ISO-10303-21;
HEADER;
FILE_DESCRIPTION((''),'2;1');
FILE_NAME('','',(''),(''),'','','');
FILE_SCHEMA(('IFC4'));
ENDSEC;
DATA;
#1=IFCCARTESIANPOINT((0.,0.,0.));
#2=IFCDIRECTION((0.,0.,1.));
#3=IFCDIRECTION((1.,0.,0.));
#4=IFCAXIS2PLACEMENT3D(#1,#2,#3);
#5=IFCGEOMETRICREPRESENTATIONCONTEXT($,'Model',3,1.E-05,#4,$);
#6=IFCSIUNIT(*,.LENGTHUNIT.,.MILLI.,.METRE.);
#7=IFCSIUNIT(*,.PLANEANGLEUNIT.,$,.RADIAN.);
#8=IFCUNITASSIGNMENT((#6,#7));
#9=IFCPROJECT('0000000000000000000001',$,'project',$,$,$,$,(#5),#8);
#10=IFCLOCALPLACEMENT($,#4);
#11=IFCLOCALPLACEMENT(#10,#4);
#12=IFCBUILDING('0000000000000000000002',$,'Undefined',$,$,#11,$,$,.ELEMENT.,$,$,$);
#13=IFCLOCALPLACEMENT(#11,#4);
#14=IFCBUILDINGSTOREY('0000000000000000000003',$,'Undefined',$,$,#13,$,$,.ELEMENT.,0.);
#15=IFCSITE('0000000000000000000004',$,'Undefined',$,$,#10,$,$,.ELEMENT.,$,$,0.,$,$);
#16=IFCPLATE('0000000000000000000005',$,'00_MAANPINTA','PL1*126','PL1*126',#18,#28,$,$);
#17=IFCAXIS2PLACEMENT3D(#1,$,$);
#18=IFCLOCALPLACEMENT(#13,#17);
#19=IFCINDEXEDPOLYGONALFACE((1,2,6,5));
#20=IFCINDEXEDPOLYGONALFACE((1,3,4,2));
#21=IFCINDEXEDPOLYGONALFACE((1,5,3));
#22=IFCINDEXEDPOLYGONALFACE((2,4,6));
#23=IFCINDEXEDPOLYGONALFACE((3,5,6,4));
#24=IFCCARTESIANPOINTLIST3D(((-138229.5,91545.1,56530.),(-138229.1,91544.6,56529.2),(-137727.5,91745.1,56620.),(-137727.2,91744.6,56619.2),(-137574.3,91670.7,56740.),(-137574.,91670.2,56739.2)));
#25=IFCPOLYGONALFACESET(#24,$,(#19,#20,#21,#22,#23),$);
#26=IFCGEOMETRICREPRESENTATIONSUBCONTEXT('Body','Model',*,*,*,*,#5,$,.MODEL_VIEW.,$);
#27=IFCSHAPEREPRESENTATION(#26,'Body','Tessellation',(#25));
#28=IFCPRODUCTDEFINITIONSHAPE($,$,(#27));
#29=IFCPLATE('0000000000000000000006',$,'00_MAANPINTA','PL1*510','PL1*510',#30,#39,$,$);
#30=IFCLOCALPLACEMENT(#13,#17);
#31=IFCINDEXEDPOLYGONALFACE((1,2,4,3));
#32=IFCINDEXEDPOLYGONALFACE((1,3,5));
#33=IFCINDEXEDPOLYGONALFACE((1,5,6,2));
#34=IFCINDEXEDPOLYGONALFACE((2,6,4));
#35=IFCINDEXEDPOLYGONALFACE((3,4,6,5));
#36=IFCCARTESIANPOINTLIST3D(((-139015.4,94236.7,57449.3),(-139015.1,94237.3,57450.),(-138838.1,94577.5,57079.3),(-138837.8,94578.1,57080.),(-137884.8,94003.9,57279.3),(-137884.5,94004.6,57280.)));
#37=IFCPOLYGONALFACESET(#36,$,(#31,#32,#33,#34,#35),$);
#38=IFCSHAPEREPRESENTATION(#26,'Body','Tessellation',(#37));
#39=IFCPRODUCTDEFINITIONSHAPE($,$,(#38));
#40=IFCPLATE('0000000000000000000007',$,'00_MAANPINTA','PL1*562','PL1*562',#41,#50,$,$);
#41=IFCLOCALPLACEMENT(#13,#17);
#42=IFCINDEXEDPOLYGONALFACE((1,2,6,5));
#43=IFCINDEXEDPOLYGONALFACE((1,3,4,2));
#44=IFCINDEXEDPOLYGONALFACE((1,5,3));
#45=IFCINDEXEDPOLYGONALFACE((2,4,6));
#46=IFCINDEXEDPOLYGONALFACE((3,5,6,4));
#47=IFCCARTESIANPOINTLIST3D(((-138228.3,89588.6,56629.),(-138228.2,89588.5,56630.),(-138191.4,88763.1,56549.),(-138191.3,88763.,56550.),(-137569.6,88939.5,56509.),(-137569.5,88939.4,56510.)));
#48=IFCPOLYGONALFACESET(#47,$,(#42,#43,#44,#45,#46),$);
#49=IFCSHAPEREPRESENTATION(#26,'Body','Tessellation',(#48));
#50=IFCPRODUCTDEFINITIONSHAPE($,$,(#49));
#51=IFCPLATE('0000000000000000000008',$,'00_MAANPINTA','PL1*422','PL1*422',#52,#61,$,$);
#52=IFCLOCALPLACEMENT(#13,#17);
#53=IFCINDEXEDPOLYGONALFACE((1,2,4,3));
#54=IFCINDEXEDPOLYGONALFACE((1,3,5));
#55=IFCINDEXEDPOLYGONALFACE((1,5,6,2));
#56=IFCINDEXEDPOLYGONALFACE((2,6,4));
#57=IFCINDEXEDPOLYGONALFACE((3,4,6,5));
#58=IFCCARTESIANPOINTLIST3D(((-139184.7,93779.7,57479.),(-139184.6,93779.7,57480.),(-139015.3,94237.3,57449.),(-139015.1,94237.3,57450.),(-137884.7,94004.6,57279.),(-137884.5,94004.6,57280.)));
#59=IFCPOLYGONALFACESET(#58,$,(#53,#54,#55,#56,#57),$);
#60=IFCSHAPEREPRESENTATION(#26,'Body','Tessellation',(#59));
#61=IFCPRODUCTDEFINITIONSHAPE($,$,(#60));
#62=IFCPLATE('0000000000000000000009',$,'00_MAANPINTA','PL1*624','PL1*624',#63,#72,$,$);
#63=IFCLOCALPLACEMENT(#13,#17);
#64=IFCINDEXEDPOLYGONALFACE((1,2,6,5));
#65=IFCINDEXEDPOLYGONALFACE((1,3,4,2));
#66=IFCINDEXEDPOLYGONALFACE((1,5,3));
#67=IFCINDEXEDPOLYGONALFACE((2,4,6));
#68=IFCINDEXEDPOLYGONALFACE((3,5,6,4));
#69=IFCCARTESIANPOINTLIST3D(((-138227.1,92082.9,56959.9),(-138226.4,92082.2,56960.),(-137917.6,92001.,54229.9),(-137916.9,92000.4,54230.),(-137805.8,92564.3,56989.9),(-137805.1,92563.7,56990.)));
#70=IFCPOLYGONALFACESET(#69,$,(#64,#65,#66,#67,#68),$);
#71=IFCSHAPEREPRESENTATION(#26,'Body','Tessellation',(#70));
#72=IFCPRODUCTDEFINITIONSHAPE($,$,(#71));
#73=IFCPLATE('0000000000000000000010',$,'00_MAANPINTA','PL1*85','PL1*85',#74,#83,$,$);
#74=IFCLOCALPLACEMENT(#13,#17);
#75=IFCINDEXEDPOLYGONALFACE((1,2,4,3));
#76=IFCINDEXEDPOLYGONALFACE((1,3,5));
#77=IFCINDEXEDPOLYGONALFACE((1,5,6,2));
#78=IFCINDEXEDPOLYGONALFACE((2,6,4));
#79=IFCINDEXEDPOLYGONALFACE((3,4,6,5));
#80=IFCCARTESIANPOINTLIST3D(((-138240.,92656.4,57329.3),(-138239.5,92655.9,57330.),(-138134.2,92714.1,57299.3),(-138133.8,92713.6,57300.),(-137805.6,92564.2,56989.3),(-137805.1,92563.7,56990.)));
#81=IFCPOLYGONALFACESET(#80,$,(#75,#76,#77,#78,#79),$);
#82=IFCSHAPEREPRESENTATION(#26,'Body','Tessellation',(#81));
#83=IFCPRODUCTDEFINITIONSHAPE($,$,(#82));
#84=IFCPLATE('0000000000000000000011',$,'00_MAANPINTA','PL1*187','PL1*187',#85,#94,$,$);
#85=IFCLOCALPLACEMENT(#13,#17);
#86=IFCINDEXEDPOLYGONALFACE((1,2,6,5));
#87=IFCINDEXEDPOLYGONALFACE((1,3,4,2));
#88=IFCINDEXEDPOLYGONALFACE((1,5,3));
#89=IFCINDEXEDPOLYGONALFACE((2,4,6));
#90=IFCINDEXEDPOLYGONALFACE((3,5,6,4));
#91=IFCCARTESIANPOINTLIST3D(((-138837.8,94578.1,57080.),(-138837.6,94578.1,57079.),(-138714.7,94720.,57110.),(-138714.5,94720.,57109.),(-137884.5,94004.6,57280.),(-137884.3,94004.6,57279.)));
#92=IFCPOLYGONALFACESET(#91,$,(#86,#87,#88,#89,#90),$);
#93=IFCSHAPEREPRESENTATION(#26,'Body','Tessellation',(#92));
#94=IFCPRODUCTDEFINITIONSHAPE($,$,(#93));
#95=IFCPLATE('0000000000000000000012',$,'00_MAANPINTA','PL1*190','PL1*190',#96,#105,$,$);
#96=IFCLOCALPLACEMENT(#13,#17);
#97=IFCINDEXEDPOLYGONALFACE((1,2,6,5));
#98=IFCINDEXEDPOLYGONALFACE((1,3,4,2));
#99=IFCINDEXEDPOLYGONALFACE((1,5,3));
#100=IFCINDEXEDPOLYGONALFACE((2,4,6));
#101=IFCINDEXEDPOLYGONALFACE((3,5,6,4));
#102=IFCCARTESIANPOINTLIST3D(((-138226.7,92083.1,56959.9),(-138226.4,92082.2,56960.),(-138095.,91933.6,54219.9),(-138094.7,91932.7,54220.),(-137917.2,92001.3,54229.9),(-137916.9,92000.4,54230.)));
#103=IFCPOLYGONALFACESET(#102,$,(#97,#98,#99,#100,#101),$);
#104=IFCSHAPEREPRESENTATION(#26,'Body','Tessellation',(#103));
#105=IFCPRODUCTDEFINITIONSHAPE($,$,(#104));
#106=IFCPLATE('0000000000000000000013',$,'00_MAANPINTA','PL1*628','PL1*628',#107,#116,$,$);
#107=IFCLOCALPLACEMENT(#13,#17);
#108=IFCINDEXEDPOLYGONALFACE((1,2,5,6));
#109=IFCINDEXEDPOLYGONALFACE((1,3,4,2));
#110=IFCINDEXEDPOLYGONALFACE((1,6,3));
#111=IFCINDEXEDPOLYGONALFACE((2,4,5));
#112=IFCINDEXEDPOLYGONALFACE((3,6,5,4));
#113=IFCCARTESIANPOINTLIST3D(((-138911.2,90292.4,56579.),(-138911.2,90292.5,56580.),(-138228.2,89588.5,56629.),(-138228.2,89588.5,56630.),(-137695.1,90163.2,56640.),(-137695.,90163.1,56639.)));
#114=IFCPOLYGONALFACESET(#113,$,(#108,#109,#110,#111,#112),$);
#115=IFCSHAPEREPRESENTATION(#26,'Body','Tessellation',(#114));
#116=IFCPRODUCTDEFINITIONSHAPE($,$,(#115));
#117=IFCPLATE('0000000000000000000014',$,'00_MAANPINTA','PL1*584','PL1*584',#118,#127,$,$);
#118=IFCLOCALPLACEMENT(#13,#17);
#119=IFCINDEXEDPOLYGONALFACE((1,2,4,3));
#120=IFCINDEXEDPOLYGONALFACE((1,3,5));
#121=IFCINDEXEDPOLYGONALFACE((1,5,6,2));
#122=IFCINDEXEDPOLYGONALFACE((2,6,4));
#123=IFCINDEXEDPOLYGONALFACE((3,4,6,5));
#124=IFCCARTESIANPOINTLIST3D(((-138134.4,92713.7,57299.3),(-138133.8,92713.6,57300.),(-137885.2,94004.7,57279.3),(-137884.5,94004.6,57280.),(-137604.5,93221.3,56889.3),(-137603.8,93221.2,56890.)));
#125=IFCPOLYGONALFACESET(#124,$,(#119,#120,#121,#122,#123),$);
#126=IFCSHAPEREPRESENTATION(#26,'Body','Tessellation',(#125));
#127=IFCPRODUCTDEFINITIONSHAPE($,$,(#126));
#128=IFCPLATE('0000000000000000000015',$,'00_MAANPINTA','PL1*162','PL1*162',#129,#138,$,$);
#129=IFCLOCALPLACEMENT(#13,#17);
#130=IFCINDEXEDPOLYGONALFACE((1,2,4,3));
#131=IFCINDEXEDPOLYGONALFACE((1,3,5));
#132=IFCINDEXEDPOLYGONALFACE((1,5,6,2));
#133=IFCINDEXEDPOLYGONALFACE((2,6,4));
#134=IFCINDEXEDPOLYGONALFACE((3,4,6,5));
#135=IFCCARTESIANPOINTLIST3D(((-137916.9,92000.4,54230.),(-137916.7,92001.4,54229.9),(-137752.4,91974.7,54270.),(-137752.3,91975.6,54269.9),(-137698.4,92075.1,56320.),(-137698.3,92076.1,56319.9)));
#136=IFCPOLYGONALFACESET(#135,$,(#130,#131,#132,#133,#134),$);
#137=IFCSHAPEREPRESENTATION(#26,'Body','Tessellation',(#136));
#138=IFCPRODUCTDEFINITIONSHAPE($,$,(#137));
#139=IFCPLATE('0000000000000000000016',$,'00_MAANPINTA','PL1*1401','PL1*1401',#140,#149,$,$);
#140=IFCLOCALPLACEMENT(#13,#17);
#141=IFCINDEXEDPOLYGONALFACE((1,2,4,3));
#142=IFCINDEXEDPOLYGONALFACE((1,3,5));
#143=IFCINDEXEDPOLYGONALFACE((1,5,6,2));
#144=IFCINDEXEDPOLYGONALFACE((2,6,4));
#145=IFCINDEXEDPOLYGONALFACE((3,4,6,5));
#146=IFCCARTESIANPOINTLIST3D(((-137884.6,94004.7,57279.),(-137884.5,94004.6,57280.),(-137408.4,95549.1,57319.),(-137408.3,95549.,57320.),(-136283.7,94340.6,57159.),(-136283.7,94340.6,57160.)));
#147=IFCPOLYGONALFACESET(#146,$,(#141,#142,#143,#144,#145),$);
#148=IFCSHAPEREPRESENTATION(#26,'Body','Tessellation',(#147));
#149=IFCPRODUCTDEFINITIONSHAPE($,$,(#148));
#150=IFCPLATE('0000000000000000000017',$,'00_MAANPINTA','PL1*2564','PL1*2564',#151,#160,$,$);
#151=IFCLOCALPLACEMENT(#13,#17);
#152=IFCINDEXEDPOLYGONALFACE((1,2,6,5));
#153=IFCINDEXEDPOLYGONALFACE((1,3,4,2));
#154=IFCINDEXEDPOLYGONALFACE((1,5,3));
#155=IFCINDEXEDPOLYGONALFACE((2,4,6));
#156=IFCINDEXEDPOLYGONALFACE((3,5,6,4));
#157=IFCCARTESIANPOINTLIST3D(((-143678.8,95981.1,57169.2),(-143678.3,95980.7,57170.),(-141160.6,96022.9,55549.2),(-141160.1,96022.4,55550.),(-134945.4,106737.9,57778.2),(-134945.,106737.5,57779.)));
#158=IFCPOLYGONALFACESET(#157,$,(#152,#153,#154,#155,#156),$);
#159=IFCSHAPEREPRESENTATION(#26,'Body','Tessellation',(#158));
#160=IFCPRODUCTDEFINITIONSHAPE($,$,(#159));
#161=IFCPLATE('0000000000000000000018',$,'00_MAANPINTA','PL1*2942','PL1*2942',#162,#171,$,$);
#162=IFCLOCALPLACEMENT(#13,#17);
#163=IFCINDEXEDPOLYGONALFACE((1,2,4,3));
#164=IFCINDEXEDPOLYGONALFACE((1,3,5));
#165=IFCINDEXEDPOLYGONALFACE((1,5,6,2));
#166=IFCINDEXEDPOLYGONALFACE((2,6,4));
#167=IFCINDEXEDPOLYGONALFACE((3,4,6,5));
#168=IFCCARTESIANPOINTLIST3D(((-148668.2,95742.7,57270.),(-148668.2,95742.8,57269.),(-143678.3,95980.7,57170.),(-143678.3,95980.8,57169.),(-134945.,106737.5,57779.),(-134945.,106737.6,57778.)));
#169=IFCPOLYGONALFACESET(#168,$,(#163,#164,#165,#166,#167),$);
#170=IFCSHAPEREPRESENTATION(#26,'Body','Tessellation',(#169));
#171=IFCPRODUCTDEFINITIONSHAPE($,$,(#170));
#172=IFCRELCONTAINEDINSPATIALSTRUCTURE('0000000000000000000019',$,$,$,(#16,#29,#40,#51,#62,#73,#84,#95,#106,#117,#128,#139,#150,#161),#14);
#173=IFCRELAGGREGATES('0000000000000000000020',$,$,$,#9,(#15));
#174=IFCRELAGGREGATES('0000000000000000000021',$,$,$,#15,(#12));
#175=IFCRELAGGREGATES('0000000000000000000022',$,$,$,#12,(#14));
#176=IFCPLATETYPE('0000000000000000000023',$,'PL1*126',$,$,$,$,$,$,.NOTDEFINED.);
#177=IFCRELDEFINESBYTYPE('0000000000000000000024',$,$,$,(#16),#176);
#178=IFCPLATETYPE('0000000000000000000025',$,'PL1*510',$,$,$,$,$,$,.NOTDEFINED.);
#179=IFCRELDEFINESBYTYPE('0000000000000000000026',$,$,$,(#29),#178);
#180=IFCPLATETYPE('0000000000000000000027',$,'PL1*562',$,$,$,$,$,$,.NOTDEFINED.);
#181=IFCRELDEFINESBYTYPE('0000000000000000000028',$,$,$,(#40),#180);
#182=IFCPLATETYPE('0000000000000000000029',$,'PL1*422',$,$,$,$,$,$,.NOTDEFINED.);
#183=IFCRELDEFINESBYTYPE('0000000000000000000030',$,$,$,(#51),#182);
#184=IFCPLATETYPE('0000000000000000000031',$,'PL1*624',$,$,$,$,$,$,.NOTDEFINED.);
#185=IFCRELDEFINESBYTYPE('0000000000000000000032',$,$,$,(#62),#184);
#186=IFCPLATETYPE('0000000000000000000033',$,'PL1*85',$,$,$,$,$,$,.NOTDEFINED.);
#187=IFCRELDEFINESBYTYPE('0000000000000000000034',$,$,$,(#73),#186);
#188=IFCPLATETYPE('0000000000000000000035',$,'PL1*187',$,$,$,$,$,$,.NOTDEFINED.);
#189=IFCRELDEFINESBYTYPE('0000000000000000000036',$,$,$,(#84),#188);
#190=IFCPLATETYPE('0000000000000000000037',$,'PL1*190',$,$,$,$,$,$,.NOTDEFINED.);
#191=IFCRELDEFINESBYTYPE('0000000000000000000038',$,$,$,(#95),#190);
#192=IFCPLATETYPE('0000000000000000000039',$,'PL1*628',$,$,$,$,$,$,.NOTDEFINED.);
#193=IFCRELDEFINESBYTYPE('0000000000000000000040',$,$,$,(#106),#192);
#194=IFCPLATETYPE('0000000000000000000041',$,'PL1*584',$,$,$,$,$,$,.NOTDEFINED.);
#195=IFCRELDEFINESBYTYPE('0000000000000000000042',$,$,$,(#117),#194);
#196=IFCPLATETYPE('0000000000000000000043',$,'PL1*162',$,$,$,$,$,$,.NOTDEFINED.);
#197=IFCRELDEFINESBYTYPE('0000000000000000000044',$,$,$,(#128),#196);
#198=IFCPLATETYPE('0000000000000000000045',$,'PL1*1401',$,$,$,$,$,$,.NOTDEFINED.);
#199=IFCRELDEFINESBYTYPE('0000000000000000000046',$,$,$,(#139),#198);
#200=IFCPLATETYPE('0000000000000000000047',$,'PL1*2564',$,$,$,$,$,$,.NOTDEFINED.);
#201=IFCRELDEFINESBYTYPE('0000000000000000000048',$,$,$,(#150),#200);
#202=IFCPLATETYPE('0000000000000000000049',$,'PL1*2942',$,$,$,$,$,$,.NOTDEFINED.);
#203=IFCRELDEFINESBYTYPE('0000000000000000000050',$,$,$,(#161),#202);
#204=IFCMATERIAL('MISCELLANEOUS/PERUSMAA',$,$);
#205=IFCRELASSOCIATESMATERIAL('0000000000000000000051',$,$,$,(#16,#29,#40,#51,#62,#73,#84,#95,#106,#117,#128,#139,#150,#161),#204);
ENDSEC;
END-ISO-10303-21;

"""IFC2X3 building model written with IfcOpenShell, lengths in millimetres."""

from ifc_helpers import new_model, si_unit, frame, origin_with_axes, place, context, subcontext, project, spatial, polyline, outline, extrude, material, type_object, element, save


model = new_model("IFC2X3")

# Units and contexts
model_context = context("Model", 3, precision=1e-05, world=origin_with_axes())
body_context = subcontext(model_context, "Body", "Model", "MODEL_VIEW")
ifc_project = project(units=[si_unit("LENGTHUNIT", "METRE", prefix="MILLI"), si_unit("PLANEANGLEUNIT", "RADIAN")], contexts=[model_context])

# Site, building, storey
site_placement = place(None, origin_with_axes())
site = spatial("IfcSite", under=ifc_project, at=site_placement, Name="Undefined", CompositionType="ELEMENT", RefElevation=0.0)
building_placement = place(site_placement, origin_with_axes())
building = spatial("IfcBuilding", under=site, at=building_placement, Name="Undefined", CompositionType="ELEMENT")
storey_placement = place(building_placement, origin_with_axes())
storey = spatial("IfcBuildingStorey", under=building, at=storey_placement, Name="Undefined", CompositionType="ELEMENT", Elevation=0.0)

# Plates
ifc_material = material(Name="MISCELLANEOUS/PERUSMAA")
plate_type_1 = type_object("IfcPlateType", Name="PL1*126", PredefinedType="NOTDEFINED")
plate_1_placement = place(storey_placement, frame((-138229.3, 91544.8, 56529.6), z_axis=(0.349353, -0.528524, -0.773702), x_axis=(0.916324, 0.365185, 0.164289)))
element("IfcPlate", 1, at=plate_1_placement, inside=storey, type_object=plate_type_1, material=ifc_material, Name="00_MAANPINTA", Description="PL1*126", ObjectType="PL1*126", context=body_context, shape_type="SweptSolid", body=[
    extrude(outline(polyline([(0.0, 0.0), (547.8, 0.0), (680.7, 160.4), (0.0, 0.0)])), frame((0.0, 0.0, -0.5), z_axis=(0.0, 0.0, 1.0), x_axis=(1.0, 0.0, 0.0)), (0.0, 0.0, 1.0), 1.0),
])
plate_type_2 = type_object("IfcPlateType", Name="PL1*510", PredefinedType="NOTDEFINED")
plate_2_placement = place(storey_placement, frame((-139015.3, 94237.0, 57449.6), z_axis=(-0.242286, -0.652972, -0.717583), x_axis=(0.332479, 0.638954, -0.693682)))
element("IfcPlate", 2, at=plate_2_placement, inside=storey, type_object=plate_type_2, material=ifc_material, Name="00_MAANPINTA", Description="PL1*510", ObjectType="PL1*510", context=body_context, shape_type="SweptSolid", body=[
    extrude(outline(polyline([(0.0, 0.0), (533.4, 0.0), (345.2, 1114.6), (0.0, 0.0)])), frame((0.0, 0.0, -0.5), z_axis=(0.0, 0.0, 1.0), x_axis=(1.0, 0.0, 0.0)), (0.0, 0.0, 1.0), 1.0),
])
plate_type_3 = type_object("IfcPlateType", Name="PL1*562", PredefinedType="NOTDEFINED")
plate_3_placement = place(storey_placement, frame((-138228.3, 89588.6, 56629.5), z_axis=(-0.089933, 0.092072, -0.991683), x_axis=(0.706365, -0.696053, -0.128683)))
element("IfcPlate", 3, at=plate_3_placement, inside=storey, type_object=plate_type_3, material=ifc_material, Name="00_MAANPINTA", Description="PL1*562", ObjectType="PL1*562", context=body_context, shape_type="SweptSolid", body=[
    extrude(outline(polyline([(0.0, 0.0), (932.5, 0.0), (611.0, 562.1), (0.0, 0.0)])), frame((0.0, 0.0, -0.5), z_axis=(0.0, 0.0, 1.0), x_axis=(1.0, 0.0, 0.0)), (0.0, 0.0, 1.0), 1.0),
])
plate_type_4 = type_object("IfcPlateType", Name="PL1*422", PredefinedType="NOTDEFINED")
plate_4_placement = place(storey_placement, frame((-139184.7, 93779.7, 57479.5), z_axis=(-0.150507, -0.009079, -0.988567), x_axis=(0.346603, 0.936002, -0.061365)))
element("IfcPlate", 4, at=plate_4_placement, inside=storey, type_object=plate_type_4, material=ifc_material, Name="00_MAANPINTA", Description="PL1*422", ObjectType="PL1*422", context=body_context, shape_type="SweptSolid", body=[
    extrude(outline(polyline([(0.0, 0.0), (488.9, 0.0), (673.4, 1152.1), (0.0, 0.0)])), frame((0.0, 0.0, -0.5), z_axis=(0.0, 0.0, 1.0), x_axis=(1.0, 0.0, 0.0)), (0.0, 0.0, 1.0), 1.0),
])
plate_type_5 = type_object("IfcPlateType", Name="PL1*624", PredefinedType="NOTDEFINED")
plate_5_placement = place(storey_placement, frame((-137917.2, 92000.7, 54229.9), z_axis=(-0.745235, 0.658605, -0.104235), x_axis=(-0.112606, 0.029772, 0.993194)))
element("IfcPlate", 5, at=plate_5_placement, inside=storey, type_object=plate_type_5, material=ifc_material, Name="00_MAANPINTA", Description="PL1*624", ObjectType="PL1*624", context=body_context, shape_type="SweptSolid", body=[
    extrude(outline(polyline([(0.0, 0.0), (2748.7, 0.0), (2745.4, 640.5), (0.0, 0.0)])), frame((0.0, 0.0, -0.5), z_axis=(0.0, 0.0, 1.0), x_axis=(1.0, 0.0, 0.0)), (0.0, 0.0, 1.0), 1.0),
])
plate_type_6 = type_object("IfcPlateType", Name="PL1*85", PredefinedType="NOTDEFINED")
plate_6_placement = place(storey_placement, frame((-137805.3, 92563.9, 56989.6), z_axis=(-0.473107, 0.484434, -0.735863), x_axis=(-0.776684, 0.164914, 0.607919)))
element("IfcPlate", 6, at=plate_6_placement, inside=storey, type_object=plate_type_6, material=ifc_material, Name="00_MAANPINTA", Description="PL1*85", ObjectType="PL1*85", context=body_context, shape_type="SweptSolid", body=[
    extrude(outline(polyline([(0.0, 0.0), (559.3, 0.0), (468.5, 84.6), (0.0, 0.0)])), frame((0.0, 0.0, -0.5), z_axis=(0.0, 0.0, 1.0), x_axis=(1.0, 0.0, 0.0)), (0.0, 0.0, 1.0), 1.0),
])
plate_type_7 = type_object("IfcPlateType", Name="PL1*187", PredefinedType="NOTDEFINED")
plate_7_placement = place(storey_placement, frame((-138837.7, 94578.1, 57079.5), z_axis=(0.216129, 0.018831, -0.976183), x_axis=(0.647187, 0.745847, 0.157676)))
element("IfcPlate", 7, at=plate_7_placement, inside=storey, type_object=plate_type_7, material=ifc_material, Name="00_MAANPINTA", Description="PL1*187", ObjectType="PL1*187", context=body_context, shape_type="SweptSolid", body=[
    extrude(outline(polyline([(0.0, 0.0), (190.3, 0.0), (220.7, 1108.6), (0.0, 0.0)])), frame((0.0, 0.0, -0.5), z_axis=(0.0, 0.0, 1.0), x_axis=(1.0, 0.0, 0.0)), (0.0, 0.0, 1.0), 1.0),
])
plate_type_8 = type_object("IfcPlateType", Name="PL1*190", PredefinedType="NOTDEFINED")
plate_8_placement = place(storey_placement, frame((-138226.6, 92082.7, 56960.0), z_axis=(-0.351559, 0.933704, -0.067848), x_axis=(0.112606, -0.029772, -0.993194)))
element("IfcPlate", 8, at=plate_8_placement, inside=storey, type_object=plate_type_8, material=ifc_material, Name="00_MAANPINTA", Description="PL1*190", ObjectType="PL1*190", context=body_context, shape_type="SweptSolid", body=[
    extrude(outline(polyline([(0.0, 0.0), (2748.7, 0.0), (2740.6, 190.4), (0.0, 0.0)])), frame((0.0, 0.0, -0.5), z_axis=(0.0, 0.0, 1.0), x_axis=(1.0, 0.0, 0.0)), (0.0, 0.0, 1.0), 1.0),
])
plate_type_9 = type_object("IfcPlateType", Name="PL1*628", PredefinedType="NOTDEFINED")
plate_9_placement = place(storey_placement, frame((-138228.2, 89588.5, 56629.5), z_axis=(0.046525, -0.025789, -0.998584), x_axis=(-0.695418, 0.7168, -0.050912)))
element("IfcPlate", 9, at=plate_9_placement, inside=storey, type_object=plate_type_9, material=ifc_material, Name="00_MAANPINTA", Description="PL1*628", ObjectType="PL1*628", context=body_context, shape_type="SweptSolid", body=[
    extrude(outline(polyline([(0.0, 0.0), (982.1, 0.0), (40.6, 782.9), (0.0, 0.0)])), frame((0.0, 0.0, -0.5), z_axis=(0.0, 0.0, 1.0), x_axis=(1.0, 0.0, 0.0)), (0.0, 0.0, 1.0), 1.0),
])
plate_type_10 = type_object("IfcPlateType", Name="PL1*584", PredefinedType="NOTDEFINED")
plate_10_placement = place(storey_placement, frame((-137884.8, 94004.7, 57279.6), z_axis=(-0.6765, 0.119357, -0.726706), x_axis=(0.305465, -0.852412, -0.424365)))
element("IfcPlate", 10, at=plate_10_placement, inside=storey, type_object=plate_type_10, material=ifc_material, Name="00_MAANPINTA", Description="PL1*584", ObjectType="PL1*584", context=body_context, shape_type="SweptSolid", body=[
    extrude(outline(polyline([(0.0, 0.0), (919.0, 0.0), (1015.9, 835.1), (0.0, 0.0)])), frame((0.0, 0.0, -0.5), z_axis=(0.0, 0.0, 1.0), x_axis=(1.0, 0.0, 0.0)), (0.0, 0.0, 1.0), 1.0),
])
plate_type_11 = type_object("IfcPlateType", Name="PL1*162", PredefinedType="NOTDEFINED")
plate_11_placement = place(storey_placement, frame((-137752.4, 91975.2, 54270.0), z_axis=(0.166724, 0.984598, -0.05262), x_axis=(-0.960645, 0.150179, -0.233682)))
element("IfcPlate", 11, at=plate_11_placement, inside=storey, type_object=plate_type_11, material=ifc_material, Name="00_MAANPINTA", Description="PL1*162", ObjectType="PL1*162", context=body_context, shape_type="SweptSolid", body=[
    extrude(outline(polyline([(0.0, 0.0), (171.2, 0.0), (-515.9, 1987.3), (0.0, 0.0)])), frame((0.0, 0.0, -0.5), z_axis=(0.0, 0.0, 1.0), x_axis=(1.0, 0.0, 0.0)), (0.0, 0.0, 1.0), 1.0),
])
plate_type_12 = type_object("IfcPlateType", Name="PL1*1401", PredefinedType="NOTDEFINED")
plate_12_placement = place(storey_placement, frame((-137884.6, 94004.6, 57279.5), z_axis=(-0.085526, 0.052139, -0.994971), x_axis=(0.294548, 0.955316, 0.024742)))
element("IfcPlate", 12, at=plate_12_placement, inside=storey, type_object=plate_type_12, material=ifc_material, Name="00_MAANPINTA", Description="PL1*1401", ObjectType="PL1*1401", context=body_context, shape_type="SweptSolid", body=[
    extrude(outline(polyline([(0.0, 0.0), (1616.7, 0.0), (789.5, 1437.6), (0.0, 0.0)])), frame((0.0, 0.0, -0.5), z_axis=(0.0, 0.0, 1.0), x_axis=(1.0, 0.0, 0.0)), (0.0, 0.0, 1.0), 1.0),
])
plate_type_13 = type_object("IfcPlateType", Name="PL1*2564", PredefinedType="NOTDEFINED")
plate_13_placement = place(storey_placement, frame((-143678.5, 95980.9, 57169.6), z_axis=(-0.490753, 0.44098, -0.751464), x_axis=(0.629698, 0.775598, 0.043911)))
element("IfcPlate", 13, at=plate_13_placement, inside=storey, type_object=plate_type_13, material=ifc_material, Name="00_MAANPINTA", Description="PL1*2564", ObjectType="PL1*2564", context=body_context, shape_type="SweptSolid", body=[
    extrude(outline(polyline([(0.0, 0.0), (13869.1, 0.0), (1546.9, 2564.0), (0.0, 0.0)])), frame((0.0, 0.0, -0.5), z_axis=(0.0, 0.0, 1.0), x_axis=(1.0, 0.0, 0.0)), (0.0, 0.0, 1.0), 1.0),
])
plate_type_14 = type_object("IfcPlateType", Name="PL1*2942", PredefinedType="NOTDEFINED")
plate_14_placement = place(storey_placement, frame((-148668.2, 95742.8, 57269.5), z_axis=(-0.023582, 0.075583, -0.996861), x_axis=(0.780092, 0.624995, 0.028934)))
element("IfcPlate", 14, at=plate_14_placement, inside=storey, type_object=plate_type_14, material=ifc_material, Name="00_MAANPINTA", Description="PL1*2942", ObjectType="PL1*2942", context=body_context, shape_type="SweptSolid", body=[
    extrude(outline(polyline([(0.0, 0.0), (17591.8, 0.0), (4038.4, 2942.3), (0.0, 0.0)])), frame((0.0, 0.0, -0.5), z_axis=(0.0, 0.0, 1.0), x_axis=(1.0, 0.0, 0.0)), (0.0, 0.0, 1.0), 1.0),
])

save(model, "model.ifc")
